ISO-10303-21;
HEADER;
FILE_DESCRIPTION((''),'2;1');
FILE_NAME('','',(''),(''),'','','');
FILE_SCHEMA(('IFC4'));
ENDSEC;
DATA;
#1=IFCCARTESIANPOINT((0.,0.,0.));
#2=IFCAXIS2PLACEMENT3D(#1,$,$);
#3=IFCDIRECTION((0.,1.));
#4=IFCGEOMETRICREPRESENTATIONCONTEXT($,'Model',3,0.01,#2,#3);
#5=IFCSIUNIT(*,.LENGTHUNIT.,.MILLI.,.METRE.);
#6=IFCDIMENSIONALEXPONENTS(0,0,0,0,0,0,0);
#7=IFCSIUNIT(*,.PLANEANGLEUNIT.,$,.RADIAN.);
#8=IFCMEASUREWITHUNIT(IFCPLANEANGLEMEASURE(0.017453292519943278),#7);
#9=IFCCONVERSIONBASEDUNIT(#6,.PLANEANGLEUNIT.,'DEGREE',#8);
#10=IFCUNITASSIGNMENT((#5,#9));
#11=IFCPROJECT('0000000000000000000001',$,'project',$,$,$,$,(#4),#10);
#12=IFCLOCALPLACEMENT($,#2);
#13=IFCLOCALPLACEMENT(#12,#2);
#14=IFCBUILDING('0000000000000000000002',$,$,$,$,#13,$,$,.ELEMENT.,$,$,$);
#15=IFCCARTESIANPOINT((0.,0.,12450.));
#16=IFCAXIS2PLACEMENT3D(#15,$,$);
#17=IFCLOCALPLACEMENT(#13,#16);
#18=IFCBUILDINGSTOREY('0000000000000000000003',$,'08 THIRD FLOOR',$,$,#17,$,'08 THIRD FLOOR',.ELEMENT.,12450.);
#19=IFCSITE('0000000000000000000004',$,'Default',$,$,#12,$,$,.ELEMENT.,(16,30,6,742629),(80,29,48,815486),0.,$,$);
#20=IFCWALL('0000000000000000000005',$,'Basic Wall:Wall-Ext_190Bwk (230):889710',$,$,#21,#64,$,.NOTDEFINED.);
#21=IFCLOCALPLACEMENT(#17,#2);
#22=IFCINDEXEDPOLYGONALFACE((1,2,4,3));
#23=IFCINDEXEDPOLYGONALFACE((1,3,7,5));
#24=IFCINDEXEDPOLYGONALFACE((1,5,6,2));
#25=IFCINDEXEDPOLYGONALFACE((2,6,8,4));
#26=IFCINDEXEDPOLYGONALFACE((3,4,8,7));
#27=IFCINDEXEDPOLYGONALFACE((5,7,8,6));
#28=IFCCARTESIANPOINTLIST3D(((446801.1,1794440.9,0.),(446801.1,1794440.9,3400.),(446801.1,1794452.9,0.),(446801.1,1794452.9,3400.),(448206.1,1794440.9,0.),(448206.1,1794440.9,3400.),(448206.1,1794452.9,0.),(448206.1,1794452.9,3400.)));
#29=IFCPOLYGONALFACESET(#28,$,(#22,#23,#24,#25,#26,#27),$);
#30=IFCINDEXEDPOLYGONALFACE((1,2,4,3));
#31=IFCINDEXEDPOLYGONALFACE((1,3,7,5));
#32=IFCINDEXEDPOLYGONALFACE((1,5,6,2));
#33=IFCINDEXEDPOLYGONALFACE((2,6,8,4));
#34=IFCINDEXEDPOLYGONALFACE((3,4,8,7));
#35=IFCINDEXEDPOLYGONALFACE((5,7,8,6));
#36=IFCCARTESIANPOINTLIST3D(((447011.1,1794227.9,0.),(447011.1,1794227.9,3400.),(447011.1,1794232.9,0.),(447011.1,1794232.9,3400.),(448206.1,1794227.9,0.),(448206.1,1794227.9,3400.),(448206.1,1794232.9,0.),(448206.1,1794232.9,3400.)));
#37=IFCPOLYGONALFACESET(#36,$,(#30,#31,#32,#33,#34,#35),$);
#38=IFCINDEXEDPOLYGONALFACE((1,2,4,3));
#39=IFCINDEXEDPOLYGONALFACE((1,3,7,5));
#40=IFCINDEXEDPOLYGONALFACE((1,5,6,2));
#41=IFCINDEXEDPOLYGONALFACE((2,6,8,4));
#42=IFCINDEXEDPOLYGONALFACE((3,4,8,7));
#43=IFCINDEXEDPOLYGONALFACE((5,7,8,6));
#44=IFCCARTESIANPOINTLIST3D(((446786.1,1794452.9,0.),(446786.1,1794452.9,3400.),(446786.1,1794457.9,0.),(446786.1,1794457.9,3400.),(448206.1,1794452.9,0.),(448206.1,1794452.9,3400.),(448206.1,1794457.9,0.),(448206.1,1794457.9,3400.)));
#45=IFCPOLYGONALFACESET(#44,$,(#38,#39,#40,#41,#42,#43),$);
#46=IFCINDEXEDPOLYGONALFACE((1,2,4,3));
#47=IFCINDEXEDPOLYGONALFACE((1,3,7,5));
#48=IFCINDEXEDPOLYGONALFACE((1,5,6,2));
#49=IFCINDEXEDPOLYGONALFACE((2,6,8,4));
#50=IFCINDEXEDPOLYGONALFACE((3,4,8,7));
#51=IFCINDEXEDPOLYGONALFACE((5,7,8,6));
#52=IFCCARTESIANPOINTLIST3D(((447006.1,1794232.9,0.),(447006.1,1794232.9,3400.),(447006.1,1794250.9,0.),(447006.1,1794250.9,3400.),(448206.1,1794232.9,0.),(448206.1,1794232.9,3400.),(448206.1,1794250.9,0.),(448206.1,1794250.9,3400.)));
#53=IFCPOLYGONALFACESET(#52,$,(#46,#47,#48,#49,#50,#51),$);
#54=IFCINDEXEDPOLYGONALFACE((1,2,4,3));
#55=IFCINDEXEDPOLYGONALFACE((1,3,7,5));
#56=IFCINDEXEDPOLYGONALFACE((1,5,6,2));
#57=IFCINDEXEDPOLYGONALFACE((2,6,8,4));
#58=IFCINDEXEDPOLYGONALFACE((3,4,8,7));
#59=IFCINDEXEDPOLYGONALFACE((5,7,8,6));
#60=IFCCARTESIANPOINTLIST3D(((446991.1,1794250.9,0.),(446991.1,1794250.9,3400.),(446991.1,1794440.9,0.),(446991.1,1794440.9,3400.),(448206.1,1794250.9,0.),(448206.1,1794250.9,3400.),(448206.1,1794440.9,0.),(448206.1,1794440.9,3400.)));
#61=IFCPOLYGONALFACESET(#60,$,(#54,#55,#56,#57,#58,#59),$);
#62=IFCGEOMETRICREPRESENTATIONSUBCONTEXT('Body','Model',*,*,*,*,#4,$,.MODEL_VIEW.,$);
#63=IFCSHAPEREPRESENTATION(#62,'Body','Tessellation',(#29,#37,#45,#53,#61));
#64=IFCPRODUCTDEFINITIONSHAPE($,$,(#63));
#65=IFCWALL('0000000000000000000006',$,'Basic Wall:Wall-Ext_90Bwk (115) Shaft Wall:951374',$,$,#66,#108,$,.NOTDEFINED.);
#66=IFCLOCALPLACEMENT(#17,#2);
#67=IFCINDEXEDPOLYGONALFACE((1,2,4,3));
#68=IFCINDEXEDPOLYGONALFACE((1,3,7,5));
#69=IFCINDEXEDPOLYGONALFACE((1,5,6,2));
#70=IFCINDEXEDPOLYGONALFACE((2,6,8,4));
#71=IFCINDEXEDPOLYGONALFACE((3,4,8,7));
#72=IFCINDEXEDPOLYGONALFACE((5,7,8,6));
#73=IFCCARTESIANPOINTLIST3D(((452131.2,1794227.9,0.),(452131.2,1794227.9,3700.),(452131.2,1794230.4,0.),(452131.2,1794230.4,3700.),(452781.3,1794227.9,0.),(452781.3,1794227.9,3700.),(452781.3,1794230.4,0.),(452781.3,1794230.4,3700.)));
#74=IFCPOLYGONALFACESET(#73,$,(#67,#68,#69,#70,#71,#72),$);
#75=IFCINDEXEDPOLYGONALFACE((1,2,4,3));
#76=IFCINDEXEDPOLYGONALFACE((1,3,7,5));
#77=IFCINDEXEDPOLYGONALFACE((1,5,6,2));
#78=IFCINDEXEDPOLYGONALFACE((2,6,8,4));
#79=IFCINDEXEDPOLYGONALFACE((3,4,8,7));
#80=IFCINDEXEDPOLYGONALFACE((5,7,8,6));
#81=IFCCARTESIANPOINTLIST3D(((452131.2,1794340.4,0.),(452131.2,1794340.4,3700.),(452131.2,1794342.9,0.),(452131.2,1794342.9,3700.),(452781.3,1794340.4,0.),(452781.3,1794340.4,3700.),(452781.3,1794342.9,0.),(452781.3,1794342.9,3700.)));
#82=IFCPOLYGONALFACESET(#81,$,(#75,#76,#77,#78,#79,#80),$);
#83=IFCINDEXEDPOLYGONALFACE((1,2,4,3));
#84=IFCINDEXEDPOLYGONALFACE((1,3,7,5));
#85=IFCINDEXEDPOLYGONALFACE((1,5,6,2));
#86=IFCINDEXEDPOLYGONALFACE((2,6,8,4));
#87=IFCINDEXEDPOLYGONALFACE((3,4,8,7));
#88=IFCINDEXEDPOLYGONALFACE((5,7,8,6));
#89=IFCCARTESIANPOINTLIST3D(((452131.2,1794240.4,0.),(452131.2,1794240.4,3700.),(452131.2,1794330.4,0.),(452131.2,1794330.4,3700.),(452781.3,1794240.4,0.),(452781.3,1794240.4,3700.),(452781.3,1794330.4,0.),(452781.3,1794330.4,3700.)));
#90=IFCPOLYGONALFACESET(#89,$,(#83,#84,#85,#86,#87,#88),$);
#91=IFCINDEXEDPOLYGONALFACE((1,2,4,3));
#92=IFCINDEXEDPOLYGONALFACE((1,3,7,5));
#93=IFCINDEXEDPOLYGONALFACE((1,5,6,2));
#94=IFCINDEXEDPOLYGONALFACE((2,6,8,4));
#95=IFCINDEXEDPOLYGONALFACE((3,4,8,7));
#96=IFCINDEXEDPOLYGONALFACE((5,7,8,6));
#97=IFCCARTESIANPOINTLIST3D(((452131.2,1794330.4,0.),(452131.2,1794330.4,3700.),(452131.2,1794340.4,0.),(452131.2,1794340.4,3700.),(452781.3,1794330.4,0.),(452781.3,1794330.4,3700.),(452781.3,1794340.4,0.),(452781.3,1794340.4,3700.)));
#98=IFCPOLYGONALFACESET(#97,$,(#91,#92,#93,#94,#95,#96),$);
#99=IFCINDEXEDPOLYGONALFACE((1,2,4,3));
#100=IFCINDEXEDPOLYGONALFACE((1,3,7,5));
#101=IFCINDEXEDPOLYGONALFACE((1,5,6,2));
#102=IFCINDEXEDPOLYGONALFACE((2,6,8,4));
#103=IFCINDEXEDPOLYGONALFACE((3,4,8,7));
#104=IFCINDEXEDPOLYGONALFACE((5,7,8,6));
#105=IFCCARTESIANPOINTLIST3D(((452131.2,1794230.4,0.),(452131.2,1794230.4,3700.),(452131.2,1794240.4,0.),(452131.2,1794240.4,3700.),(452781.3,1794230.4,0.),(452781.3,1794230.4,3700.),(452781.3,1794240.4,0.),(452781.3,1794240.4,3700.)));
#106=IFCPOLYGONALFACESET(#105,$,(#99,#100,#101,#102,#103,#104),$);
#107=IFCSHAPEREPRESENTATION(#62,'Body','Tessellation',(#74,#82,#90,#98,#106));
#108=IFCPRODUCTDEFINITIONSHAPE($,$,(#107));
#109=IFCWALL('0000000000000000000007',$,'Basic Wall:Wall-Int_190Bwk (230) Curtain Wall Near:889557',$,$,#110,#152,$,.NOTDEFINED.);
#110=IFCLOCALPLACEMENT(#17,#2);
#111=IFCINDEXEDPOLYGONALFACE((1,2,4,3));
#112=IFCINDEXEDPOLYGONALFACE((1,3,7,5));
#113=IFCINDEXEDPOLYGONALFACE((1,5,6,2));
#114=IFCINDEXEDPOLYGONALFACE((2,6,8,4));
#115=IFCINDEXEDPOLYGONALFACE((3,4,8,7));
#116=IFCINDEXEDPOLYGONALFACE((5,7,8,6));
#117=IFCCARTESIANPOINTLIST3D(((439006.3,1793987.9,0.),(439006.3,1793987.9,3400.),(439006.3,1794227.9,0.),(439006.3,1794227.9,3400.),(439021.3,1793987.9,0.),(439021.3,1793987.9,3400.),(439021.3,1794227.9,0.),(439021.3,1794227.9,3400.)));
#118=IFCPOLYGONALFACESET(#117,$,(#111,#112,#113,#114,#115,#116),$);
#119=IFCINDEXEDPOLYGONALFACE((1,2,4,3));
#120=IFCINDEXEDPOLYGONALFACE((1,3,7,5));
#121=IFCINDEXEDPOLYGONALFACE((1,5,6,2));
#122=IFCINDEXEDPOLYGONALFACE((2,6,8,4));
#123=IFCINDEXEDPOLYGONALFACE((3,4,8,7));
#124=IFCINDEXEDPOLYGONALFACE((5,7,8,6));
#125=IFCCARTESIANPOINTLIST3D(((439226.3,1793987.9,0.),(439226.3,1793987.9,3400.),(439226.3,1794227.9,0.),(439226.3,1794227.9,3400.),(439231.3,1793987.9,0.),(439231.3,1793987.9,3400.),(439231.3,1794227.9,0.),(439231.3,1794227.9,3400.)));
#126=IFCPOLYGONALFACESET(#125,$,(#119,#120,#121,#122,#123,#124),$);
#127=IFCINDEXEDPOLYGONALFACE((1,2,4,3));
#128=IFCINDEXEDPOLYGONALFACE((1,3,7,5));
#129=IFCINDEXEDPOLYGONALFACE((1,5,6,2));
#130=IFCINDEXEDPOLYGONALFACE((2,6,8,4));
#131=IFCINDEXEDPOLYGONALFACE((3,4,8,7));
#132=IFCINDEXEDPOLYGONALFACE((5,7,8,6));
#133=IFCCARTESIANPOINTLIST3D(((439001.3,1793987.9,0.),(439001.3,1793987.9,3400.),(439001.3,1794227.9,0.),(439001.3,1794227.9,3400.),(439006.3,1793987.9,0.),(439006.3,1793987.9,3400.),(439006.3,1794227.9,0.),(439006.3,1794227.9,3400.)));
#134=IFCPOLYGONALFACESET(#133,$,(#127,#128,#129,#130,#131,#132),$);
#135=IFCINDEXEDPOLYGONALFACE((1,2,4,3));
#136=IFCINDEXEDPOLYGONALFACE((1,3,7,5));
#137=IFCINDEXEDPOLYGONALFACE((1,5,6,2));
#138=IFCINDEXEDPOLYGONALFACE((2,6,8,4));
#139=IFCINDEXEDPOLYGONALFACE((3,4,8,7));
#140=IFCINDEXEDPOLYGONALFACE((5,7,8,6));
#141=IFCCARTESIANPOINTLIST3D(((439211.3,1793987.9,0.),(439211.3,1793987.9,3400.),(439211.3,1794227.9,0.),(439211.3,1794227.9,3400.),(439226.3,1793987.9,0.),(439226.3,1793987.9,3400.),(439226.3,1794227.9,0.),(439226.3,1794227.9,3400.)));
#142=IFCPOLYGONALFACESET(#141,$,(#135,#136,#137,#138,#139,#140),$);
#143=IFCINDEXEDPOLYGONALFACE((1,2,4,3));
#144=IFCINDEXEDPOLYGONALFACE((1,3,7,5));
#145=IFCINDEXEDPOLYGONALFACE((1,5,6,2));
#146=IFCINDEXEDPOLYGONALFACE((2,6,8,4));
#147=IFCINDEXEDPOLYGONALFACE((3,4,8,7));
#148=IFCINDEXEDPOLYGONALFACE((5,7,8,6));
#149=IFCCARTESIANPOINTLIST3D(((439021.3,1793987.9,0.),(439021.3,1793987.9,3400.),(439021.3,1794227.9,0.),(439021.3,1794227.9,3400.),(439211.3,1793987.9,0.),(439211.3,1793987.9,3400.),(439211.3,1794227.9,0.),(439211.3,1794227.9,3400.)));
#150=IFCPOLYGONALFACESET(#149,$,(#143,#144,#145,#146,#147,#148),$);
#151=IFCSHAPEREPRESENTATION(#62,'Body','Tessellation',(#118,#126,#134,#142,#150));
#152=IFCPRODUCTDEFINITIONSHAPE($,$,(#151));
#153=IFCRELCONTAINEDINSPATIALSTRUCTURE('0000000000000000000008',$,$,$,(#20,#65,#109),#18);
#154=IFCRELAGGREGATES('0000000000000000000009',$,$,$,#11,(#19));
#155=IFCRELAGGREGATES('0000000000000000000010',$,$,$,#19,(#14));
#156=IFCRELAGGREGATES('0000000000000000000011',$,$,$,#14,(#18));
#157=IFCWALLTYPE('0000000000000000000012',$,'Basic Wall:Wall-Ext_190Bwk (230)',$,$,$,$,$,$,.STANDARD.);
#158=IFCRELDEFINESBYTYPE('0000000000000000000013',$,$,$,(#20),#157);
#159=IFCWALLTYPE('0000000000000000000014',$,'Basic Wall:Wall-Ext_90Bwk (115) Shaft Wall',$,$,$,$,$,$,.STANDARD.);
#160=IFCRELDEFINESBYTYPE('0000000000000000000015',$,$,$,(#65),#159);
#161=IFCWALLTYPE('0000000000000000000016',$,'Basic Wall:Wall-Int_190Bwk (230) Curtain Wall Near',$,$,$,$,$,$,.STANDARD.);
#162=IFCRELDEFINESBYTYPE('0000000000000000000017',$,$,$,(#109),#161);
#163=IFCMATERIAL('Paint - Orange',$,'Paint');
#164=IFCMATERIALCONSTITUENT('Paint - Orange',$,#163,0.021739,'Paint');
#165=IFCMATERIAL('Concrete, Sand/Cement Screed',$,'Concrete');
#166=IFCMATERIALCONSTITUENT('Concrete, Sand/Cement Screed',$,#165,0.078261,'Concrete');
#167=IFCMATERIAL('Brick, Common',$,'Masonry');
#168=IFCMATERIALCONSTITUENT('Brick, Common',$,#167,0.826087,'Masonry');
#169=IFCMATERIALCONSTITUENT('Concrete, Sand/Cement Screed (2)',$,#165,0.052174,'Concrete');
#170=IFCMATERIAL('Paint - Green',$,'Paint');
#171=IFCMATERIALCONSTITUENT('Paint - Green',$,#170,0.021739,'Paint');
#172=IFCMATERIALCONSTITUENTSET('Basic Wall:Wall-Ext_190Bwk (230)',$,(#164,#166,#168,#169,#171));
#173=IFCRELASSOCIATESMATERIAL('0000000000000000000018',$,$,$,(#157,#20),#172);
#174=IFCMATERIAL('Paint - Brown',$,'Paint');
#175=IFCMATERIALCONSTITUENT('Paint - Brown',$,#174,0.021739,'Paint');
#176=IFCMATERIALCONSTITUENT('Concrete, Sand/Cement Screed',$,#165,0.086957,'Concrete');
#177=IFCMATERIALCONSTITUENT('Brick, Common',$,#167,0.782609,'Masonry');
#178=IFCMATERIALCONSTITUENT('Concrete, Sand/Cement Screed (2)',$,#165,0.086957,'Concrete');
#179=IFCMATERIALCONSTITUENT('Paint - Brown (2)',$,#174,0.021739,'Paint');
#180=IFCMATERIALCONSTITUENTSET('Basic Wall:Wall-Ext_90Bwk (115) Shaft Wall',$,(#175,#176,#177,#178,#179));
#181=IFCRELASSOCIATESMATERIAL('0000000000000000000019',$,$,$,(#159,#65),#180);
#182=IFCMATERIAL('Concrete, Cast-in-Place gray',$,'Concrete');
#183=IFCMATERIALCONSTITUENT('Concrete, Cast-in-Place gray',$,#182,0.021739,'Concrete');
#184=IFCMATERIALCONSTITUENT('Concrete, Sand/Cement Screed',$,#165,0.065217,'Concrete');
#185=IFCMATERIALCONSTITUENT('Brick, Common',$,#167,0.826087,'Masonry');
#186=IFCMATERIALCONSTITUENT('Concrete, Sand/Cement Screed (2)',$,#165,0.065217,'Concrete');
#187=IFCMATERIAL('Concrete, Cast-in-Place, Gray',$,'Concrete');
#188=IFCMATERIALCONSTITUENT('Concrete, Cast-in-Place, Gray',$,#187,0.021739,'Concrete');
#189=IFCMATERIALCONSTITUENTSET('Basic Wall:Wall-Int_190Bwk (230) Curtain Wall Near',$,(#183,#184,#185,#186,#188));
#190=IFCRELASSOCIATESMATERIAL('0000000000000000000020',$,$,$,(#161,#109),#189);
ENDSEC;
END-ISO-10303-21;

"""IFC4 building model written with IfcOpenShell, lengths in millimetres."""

from ifc_helpers import new_model, entity, si_unit, converted_unit, direction, frame, origin, place, context, subcontext, project, spatial, indexed_curve, outline, extrude, material, constituent, constituent_set, type_object, element, save


model = new_model("IFC4")

# Units and contexts
model_context = context("Model", 3, precision=0.01, world=origin(), true_north=direction((0.0, 1.0)))
body_context = subcontext(model_context, "Body", "Model", "MODEL_VIEW")
ifc_project = project(units=[si_unit("LENGTHUNIT", "METRE", prefix="MILLI"), converted_unit("PLANEANGLEUNIT", "DEGREE", entity("IfcPlaneAngleMeasure", 0.017453292519943278), si_unit("PLANEANGLEUNIT", "RADIAN"), dimensions=[0, 0, 0, 0, 0, 0, 0])], contexts=[model_context])

# Site, building, storey
site_placement = place(None, origin())
site = spatial("IfcSite", under=ifc_project, at=site_placement, Name="Default", CompositionType="ELEMENT", RefLatitude=(16, 30, 6, 742629), RefLongitude=(80, 29, 48, 815486), RefElevation=0.0)
building_placement = place(site_placement, origin())
building = spatial("IfcBuilding", under=site, at=building_placement, CompositionType="ELEMENT")
storey_placement = place(building_placement, frame((0.0, 0.0, 12450.0)))
storey = spatial("IfcBuildingStorey", under=building, at=storey_placement, Name="08 THIRD FLOOR", LongName="08 THIRD FLOOR", CompositionType="ELEMENT", Elevation=12450.0)

# Shared definitions
ifc_material_1 = material(Name="Concrete, Sand/Cement Screed", Category="Concrete")
ifc_material_2 = material(Name="Brick, Common", Category="Masonry")

# Shared definitions
ifc_material_3 = material(Name="Paint - Orange", Category="Paint")
ifc_constituent_1 = constituent(ifc_material_3, Name="Paint - Orange", Category="Paint", fraction=0.021739)
ifc_constituent_2 = constituent(ifc_material_1, Name="Concrete, Sand/Cement Screed", Category="Concrete", fraction=0.078261)
ifc_constituent_3 = constituent(ifc_material_2, Name="Brick, Common", Category="Masonry", fraction=0.826087)
ifc_constituent_4 = constituent(ifc_material_1, Name="Concrete, Sand/Cement Screed (2)", Category="Concrete", fraction=0.052174)
ifc_material_4 = material(Name="Paint - Green", Category="Paint")
ifc_constituent_5 = constituent(ifc_material_4, Name="Paint - Green", Category="Paint", fraction=0.021739)
ifc_constituent_set_1 = constituent_set(constituents=[ifc_constituent_1, ifc_constituent_2, ifc_constituent_3, ifc_constituent_4, ifc_constituent_5], Name="Basic Wall:Wall-Ext_190Bwk (230)")
wall_type_1 = type_object("IfcWallType", Name="Basic Wall:Wall-Ext_190Bwk (230)", PredefinedType="STANDARD", material=ifc_constituent_set_1)

# Walls
wall_1_placement = place(storey_placement, frame((447011.1, 1794342.9, 0.0)))
element("IfcWall", 1, at=wall_1_placement, inside=storey, type_object=wall_type_1, material=ifc_constituent_set_1, Name="Basic Wall:Wall-Ext_190Bwk (230):889710", PredefinedType="NOTDEFINED", context=body_context, shape_type="SweptSolid", body=[
    extrude(outline(indexed_curve([(-702.5, -6.0), (702.5, -6.0), (702.5, 6.0), (-702.5, 6.0), (-702.5, -6.0)], self_intersect=False)), frame((492.5, 104.0, 0.0)), (0.0, 0.0, 1.0), 3400.0),
    extrude(outline(indexed_curve([(-2.5, -597.5), (2.5, -597.5), (2.5, 597.5), (-2.5, 597.5), (-2.5, -597.5)], self_intersect=False)), frame((597.5, -112.5, 0.0), z_axis=(0.0, 0.0, 1.0), x_axis=(0.0, 1.0, 0.0)), (0.0, 0.0, 1.0), 3400.0),
    extrude(outline(indexed_curve([(-2.5, -710.0), (2.5, -710.0), (2.5, 710.0), (-2.5, 710.0), (-2.5, -710.0)], self_intersect=False)), frame((485.0, 112.5, 0.0), z_axis=(0.0, 0.0, 1.0), x_axis=(0.0, -1.0, 0.0)), (0.0, 0.0, 1.0), 3400.0),
    extrude(outline(indexed_curve([(-600.0, -9.0), (600.0, -9.0), (600.0, 9.0), (-600.0, 9.0), (-600.0, -9.0)], self_intersect=False)), frame((595.0, -101.0, 0.0)), (0.0, 0.0, 1.0), 3400.0),
    extrude(outline(indexed_curve([(-607.5, -95.0), (607.5, -95.0), (607.5, 95.0), (-607.5, 95.0), (-607.5, -95.0)], self_intersect=False)), frame((587.5, 3.0, 0.0)), (0.0, 0.0, 1.0), 3400.0),
])
ifc_material_5 = material(Name="Paint - Brown", Category="Paint")
ifc_constituent_6 = constituent(ifc_material_5, Name="Paint - Brown", Category="Paint", fraction=0.021739)
ifc_constituent_7 = constituent(ifc_material_1, Name="Concrete, Sand/Cement Screed", Category="Concrete", fraction=0.086957)
ifc_constituent_8 = constituent(ifc_material_2, Name="Brick, Common", Category="Masonry", fraction=0.782609)
ifc_constituent_9 = constituent(ifc_material_1, Name="Concrete, Sand/Cement Screed (2)", Category="Concrete", fraction=0.086957)
ifc_constituent_10 = constituent(ifc_material_5, Name="Paint - Brown (2)", Category="Paint", fraction=0.021739)
ifc_constituent_set_2 = constituent_set(constituents=[ifc_constituent_6, ifc_constituent_7, ifc_constituent_8, ifc_constituent_9, ifc_constituent_10], Name="Basic Wall:Wall-Ext_90Bwk (115) Shaft Wall")
wall_type_2 = type_object("IfcWallType", Name="Basic Wall:Wall-Ext_90Bwk (115) Shaft Wall", PredefinedType="STANDARD", material=ifc_constituent_set_2)
wall_2_placement = place(storey_placement, frame((452131.2, 1794285.4, 0.0)))
element("IfcWall", 2, at=wall_2_placement, inside=storey, type_object=wall_type_2, material=ifc_constituent_set_2, Name="Basic Wall:Wall-Ext_90Bwk (115) Shaft Wall:951374", PredefinedType="NOTDEFINED", context=body_context, shape_type="SweptSolid", body=[
    extrude(outline(indexed_curve([(-1.2, -325.0), (1.3, -325.0), (1.3, 325.0), (-1.2, 325.0), (-1.2, -325.0)], self_intersect=False)), frame((325.0, -56.3, 0.0), z_axis=(0.0, 0.0, 1.0), x_axis=(0.0, 1.0, 0.0)), (0.0, 0.0, 1.0), 3700.0),
    extrude(outline(indexed_curve([(-1.3, -325.0), (1.3, -325.0), (1.3, 325.0), (-1.3, 325.0), (-1.3, -325.0)], self_intersect=False)), frame((325.0, 56.3, 0.0), z_axis=(0.0, 0.0, 1.0), x_axis=(0.0, -1.0, 0.0)), (0.0, 0.0, 1.0), 3700.0),
    extrude(outline(indexed_curve([(-325.0, -45.0), (325.0, -45.0), (325.0, 45.0), (-325.0, 45.0), (-325.0, -45.0)], self_intersect=False)), frame((325.0, 0.0, 0.0)), (0.0, 0.0, 1.0), 3700.0),
    extrude(outline(indexed_curve([(-325.0, -5.0), (325.0, -5.0), (325.0, 5.0), (-325.0, 5.0), (-325.0, -5.0)], self_intersect=False)), frame((325.0, 50.0, 0.0)), (0.0, 0.0, 1.0), 3700.0),
    extrude(outline(indexed_curve([(-325.0, -5.0), (325.0, -5.0), (325.0, 5.0), (-325.0, 5.0), (-325.0, -5.0)], self_intersect=False)), frame((325.0, -50.0, 0.0)), (0.0, 0.0, 1.0), 3700.0),
])
ifc_material_6 = material(Name="Concrete, Cast-in-Place gray", Category="Concrete")
ifc_constituent_11 = constituent(ifc_material_6, Name="Concrete, Cast-in-Place gray", Category="Concrete", fraction=0.021739)
ifc_constituent_12 = constituent(ifc_material_1, Name="Concrete, Sand/Cement Screed", Category="Concrete", fraction=0.065217)
ifc_constituent_13 = constituent(ifc_material_2, Name="Brick, Common", Category="Masonry", fraction=0.826087)
ifc_constituent_14 = constituent(ifc_material_1, Name="Concrete, Sand/Cement Screed (2)", Category="Concrete", fraction=0.065217)
ifc_material_7 = material(Name="Concrete, Cast-in-Place, Gray", Category="Concrete")
ifc_constituent_15 = constituent(ifc_material_7, Name="Concrete, Cast-in-Place, Gray", Category="Concrete", fraction=0.021739)
ifc_constituent_set_3 = constituent_set(constituents=[ifc_constituent_11, ifc_constituent_12, ifc_constituent_13, ifc_constituent_14, ifc_constituent_15], Name="Basic Wall:Wall-Int_190Bwk (230) Curtain Wall Near")
wall_type_3 = type_object("IfcWallType", Name="Basic Wall:Wall-Int_190Bwk (230) Curtain Wall Near", PredefinedType="STANDARD", material=ifc_constituent_set_3)
wall_3_placement = place(storey_placement, frame((439116.3, 1794227.9, 0.0), z_axis=(0.0, 0.0, 1.0), x_axis=(0.0, -1.0, 0.0)))
element("IfcWall", 3, at=wall_3_placement, inside=storey, type_object=wall_type_3, material=ifc_constituent_set_3, Name="Basic Wall:Wall-Int_190Bwk (230) Curtain Wall Near:889557", PredefinedType="NOTDEFINED", context=body_context, shape_type="SweptSolid", body=[
    extrude(outline(indexed_curve([(-120.0, -7.5), (120.0, -7.5), (120.0, 7.5), (-120.0, 7.5), (-120.0, -7.5)], self_intersect=False)), frame((120.0, -102.5, 0.0)), (0.0, 0.0, 1.0), 3400.0),
    extrude(outline(indexed_curve([(-2.5, -120.0), (2.5, -120.0), (2.5, 120.0), (-2.5, 120.0), (-2.5, -120.0)], self_intersect=False)), frame((120.0, 112.5, 0.0), z_axis=(0.0, 0.0, 1.0), x_axis=(0.0, -1.0, 0.0)), (0.0, 0.0, 1.0), 3400.0),
    extrude(outline(indexed_curve([(-2.5, -120.0), (2.5, -120.0), (2.5, 120.0), (-2.5, 120.0), (-2.5, -120.0)], self_intersect=False)), frame((120.0, -112.5, 0.0), z_axis=(0.0, 0.0, 1.0), x_axis=(0.0, 1.0, 0.0)), (0.0, 0.0, 1.0), 3400.0),
    extrude(outline(indexed_curve([(-120.0, -7.5), (120.0, -7.5), (120.0, 7.5), (-120.0, 7.5), (-120.0, -7.5)], self_intersect=False)), frame((120.0, 102.5, 0.0)), (0.0, 0.0, 1.0), 3400.0),
    extrude(outline(indexed_curve([(-120.0, -95.0), (120.0, -95.0), (120.0, 95.0), (-120.0, 95.0), (-120.0, -95.0)], self_intersect=False)), frame((120.0, 0.0, 0.0)), (0.0, 0.0, 1.0), 3400.0),
])

save(model, "model.ifc")
